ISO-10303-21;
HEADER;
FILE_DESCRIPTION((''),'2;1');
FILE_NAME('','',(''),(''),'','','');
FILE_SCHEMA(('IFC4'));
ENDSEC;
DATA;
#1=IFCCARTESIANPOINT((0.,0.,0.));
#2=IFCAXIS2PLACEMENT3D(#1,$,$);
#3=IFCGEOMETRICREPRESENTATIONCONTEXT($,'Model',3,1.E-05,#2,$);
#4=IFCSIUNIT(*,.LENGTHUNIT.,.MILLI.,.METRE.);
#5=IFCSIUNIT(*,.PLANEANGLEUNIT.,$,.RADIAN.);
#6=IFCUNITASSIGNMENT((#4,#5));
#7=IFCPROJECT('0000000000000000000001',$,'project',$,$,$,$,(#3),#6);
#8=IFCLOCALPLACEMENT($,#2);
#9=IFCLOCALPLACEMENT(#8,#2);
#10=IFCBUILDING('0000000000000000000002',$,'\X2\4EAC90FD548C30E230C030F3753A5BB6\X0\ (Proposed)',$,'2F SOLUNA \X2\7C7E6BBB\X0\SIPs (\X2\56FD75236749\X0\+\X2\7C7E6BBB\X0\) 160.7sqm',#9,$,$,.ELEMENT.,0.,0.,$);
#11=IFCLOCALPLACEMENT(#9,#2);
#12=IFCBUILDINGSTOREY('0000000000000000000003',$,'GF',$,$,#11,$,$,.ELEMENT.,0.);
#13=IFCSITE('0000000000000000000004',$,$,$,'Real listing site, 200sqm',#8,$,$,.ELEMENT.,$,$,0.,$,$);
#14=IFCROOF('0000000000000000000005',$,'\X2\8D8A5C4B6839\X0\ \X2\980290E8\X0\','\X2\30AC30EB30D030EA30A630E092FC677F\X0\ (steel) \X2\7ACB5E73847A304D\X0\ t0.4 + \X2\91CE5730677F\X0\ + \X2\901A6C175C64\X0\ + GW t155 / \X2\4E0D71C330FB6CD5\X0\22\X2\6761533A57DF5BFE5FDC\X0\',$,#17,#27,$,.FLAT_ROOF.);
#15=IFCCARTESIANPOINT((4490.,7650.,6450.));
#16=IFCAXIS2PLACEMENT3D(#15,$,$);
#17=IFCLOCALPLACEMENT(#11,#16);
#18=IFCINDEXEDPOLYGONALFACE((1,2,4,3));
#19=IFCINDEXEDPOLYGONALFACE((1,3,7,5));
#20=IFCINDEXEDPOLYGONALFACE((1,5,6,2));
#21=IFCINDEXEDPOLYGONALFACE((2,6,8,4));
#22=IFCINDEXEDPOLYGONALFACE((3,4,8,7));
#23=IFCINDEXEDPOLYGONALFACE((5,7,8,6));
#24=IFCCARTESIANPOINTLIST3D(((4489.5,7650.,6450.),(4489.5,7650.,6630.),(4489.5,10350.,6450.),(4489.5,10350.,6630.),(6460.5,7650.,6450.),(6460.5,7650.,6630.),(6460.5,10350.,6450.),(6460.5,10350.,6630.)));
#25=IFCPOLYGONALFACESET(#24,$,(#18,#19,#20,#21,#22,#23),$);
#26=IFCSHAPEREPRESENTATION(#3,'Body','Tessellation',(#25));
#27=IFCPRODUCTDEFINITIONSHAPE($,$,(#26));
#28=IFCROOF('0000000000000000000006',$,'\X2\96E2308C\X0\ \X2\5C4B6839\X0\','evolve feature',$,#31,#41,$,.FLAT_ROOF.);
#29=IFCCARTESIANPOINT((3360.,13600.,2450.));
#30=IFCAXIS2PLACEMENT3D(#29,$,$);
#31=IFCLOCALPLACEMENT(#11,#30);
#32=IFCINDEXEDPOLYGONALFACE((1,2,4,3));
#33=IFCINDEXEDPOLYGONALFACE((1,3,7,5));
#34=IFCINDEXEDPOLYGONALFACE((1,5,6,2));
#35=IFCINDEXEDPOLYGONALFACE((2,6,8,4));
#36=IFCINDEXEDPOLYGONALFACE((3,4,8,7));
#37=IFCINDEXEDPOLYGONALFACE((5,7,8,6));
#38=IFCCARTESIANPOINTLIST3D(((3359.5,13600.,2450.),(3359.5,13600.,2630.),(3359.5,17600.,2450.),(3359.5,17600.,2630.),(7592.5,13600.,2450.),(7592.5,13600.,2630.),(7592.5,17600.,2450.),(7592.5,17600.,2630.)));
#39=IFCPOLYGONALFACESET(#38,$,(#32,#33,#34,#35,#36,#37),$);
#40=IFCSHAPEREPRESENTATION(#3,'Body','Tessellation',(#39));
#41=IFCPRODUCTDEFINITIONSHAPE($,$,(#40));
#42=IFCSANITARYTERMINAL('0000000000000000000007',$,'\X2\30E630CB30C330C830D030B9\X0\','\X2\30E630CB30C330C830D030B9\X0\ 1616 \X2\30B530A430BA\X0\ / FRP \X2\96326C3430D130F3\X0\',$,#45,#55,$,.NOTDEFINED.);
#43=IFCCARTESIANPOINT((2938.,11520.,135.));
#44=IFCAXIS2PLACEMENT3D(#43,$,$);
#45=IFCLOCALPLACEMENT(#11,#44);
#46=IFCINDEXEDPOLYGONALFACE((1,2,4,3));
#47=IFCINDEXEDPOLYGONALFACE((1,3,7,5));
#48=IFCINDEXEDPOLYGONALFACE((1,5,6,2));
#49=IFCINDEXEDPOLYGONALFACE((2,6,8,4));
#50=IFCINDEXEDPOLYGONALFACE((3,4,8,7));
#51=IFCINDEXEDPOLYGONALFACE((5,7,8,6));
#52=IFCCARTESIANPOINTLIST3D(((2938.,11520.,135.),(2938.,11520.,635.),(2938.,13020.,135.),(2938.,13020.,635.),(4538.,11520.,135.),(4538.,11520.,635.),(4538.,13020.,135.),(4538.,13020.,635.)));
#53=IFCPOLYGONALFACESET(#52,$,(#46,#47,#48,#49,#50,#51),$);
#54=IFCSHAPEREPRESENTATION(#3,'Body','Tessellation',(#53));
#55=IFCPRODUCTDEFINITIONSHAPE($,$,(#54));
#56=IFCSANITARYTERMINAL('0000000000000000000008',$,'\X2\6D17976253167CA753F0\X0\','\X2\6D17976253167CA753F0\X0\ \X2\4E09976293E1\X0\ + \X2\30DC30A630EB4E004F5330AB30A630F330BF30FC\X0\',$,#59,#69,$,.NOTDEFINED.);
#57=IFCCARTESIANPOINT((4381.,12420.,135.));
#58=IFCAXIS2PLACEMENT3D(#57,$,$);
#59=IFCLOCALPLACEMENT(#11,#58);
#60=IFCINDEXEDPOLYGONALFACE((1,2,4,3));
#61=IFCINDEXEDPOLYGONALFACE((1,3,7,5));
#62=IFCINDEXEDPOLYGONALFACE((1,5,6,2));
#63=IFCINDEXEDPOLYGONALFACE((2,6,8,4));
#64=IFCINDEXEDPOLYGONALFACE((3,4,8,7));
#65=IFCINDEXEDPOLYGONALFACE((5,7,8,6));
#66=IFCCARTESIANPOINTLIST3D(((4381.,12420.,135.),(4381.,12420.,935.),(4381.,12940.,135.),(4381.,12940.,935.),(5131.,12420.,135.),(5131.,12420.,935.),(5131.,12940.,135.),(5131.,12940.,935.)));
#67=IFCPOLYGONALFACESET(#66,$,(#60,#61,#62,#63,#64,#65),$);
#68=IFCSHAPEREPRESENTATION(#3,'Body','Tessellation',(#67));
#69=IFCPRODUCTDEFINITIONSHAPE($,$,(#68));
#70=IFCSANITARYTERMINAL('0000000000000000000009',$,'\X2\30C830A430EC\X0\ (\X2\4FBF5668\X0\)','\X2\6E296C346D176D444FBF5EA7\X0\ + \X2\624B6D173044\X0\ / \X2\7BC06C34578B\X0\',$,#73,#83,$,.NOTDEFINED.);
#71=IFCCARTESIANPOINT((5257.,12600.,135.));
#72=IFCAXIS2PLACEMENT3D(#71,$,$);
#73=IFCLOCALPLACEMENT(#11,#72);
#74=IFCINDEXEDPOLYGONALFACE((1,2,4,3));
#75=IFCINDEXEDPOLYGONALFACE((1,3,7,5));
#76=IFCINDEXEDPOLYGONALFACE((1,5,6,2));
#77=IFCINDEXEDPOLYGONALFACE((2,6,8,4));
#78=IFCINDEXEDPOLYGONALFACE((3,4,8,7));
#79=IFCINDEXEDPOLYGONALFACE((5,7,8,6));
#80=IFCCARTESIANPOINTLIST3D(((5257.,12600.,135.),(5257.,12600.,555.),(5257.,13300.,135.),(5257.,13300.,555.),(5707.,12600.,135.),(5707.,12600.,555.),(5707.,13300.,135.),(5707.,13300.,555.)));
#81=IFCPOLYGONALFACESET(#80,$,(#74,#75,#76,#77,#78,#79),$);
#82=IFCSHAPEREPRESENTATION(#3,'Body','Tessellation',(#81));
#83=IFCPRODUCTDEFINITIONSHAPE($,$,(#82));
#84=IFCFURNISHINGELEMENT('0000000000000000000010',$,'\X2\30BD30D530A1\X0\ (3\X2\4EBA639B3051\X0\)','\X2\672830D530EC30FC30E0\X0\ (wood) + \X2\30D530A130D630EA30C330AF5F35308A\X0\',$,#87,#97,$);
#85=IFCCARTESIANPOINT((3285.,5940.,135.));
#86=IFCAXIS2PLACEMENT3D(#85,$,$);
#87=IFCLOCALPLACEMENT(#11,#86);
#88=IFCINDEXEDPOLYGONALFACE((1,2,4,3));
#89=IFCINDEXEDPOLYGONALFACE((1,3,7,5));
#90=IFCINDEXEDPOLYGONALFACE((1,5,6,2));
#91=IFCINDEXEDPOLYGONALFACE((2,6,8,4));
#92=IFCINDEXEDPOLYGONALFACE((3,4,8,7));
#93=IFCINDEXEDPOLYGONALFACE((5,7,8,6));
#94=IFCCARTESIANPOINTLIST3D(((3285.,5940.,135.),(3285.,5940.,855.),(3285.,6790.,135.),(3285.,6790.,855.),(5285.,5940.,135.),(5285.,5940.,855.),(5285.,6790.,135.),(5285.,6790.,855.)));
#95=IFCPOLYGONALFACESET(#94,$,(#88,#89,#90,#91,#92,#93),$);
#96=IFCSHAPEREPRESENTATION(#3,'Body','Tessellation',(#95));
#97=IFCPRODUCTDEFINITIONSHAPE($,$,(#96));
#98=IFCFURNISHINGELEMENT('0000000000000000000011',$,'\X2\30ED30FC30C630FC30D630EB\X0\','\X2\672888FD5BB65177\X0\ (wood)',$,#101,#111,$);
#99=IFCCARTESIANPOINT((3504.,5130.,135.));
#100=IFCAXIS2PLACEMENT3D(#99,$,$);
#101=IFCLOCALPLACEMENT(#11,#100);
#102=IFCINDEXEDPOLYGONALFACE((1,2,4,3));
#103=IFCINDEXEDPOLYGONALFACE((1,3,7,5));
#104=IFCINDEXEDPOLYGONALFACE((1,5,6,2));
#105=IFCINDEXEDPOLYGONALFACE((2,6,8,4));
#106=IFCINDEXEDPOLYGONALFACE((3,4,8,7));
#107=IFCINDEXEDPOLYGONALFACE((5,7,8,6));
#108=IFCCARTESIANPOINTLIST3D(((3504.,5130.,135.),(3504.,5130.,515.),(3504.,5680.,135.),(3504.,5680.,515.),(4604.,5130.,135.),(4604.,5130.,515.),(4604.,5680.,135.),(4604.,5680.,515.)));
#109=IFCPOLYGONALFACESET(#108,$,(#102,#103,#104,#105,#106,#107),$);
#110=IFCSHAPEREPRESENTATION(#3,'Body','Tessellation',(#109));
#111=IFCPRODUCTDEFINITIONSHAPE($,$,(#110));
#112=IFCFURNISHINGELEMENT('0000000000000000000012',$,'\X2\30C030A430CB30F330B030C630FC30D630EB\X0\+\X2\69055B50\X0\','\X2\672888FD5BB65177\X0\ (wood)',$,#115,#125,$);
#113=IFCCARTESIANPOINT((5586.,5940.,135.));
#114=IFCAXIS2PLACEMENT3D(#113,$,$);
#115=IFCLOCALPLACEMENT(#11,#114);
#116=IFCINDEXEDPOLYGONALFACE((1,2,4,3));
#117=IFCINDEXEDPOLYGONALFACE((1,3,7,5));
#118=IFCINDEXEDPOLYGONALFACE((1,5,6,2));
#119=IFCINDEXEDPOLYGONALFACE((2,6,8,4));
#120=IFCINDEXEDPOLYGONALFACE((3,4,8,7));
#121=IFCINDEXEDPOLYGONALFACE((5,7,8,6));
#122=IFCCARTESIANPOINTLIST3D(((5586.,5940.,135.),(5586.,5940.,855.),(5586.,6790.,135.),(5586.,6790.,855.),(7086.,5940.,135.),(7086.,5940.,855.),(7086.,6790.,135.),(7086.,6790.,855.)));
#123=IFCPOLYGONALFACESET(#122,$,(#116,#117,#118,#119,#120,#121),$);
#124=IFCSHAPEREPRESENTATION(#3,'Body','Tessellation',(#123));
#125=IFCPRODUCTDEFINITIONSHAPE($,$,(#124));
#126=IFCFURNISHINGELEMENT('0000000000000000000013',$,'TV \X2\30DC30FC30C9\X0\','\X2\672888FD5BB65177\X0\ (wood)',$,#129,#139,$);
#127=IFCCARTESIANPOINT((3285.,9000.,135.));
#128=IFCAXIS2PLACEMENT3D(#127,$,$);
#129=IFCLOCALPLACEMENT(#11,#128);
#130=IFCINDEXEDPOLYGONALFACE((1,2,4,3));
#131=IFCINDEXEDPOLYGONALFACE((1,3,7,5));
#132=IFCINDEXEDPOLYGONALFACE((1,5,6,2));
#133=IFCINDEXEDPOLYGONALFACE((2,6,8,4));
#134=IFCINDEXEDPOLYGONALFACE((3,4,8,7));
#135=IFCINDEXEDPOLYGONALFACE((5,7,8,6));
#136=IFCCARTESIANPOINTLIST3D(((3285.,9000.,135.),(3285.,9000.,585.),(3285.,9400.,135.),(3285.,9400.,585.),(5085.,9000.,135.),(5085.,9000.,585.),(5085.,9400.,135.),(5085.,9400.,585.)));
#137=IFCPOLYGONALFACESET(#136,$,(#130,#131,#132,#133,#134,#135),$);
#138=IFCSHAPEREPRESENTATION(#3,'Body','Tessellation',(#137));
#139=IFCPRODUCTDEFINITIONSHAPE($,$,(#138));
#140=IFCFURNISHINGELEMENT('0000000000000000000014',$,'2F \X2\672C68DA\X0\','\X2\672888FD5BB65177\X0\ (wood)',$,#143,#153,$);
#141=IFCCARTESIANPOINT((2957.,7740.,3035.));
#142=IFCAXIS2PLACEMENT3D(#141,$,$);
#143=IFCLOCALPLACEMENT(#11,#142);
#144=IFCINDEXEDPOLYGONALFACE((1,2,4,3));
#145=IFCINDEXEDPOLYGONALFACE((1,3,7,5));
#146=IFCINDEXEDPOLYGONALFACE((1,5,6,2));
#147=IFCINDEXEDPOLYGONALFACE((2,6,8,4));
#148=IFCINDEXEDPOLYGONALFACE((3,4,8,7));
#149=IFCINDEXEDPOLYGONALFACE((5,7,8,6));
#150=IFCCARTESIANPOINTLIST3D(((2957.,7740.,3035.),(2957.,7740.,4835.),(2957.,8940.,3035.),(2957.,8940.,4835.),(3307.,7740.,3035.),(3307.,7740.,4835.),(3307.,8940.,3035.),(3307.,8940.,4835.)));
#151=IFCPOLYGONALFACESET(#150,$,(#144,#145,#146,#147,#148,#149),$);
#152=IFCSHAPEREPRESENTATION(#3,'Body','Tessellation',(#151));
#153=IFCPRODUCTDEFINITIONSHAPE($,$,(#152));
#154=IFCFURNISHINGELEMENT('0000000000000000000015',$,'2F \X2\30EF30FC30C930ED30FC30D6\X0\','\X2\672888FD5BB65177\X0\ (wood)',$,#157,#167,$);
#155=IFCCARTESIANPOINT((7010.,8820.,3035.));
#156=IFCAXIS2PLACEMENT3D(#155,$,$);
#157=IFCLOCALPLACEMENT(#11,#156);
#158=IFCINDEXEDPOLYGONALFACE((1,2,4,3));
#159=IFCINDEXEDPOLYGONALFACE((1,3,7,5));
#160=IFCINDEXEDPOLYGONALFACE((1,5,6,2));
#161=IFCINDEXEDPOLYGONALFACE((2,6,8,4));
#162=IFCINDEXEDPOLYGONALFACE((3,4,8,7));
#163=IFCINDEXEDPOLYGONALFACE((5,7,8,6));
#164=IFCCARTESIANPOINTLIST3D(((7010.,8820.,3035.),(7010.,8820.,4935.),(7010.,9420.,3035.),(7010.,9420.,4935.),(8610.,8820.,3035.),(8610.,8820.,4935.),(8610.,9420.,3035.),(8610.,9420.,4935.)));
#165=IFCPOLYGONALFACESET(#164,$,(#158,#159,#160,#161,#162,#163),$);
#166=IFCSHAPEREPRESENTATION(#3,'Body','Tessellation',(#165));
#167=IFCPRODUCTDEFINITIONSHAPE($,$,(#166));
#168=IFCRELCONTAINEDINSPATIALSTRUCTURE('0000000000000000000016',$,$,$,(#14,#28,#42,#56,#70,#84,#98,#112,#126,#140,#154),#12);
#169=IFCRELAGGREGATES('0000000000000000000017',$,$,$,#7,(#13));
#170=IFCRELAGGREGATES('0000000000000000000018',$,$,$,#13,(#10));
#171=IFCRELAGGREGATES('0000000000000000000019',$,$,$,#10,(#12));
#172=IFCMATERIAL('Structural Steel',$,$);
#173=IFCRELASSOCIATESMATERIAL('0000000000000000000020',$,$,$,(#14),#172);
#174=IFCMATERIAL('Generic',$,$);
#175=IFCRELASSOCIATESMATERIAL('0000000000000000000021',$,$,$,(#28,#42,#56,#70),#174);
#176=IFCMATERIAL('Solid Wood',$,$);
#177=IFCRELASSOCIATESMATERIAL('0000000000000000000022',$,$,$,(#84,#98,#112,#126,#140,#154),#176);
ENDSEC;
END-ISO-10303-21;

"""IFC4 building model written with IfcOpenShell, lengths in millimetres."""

from ifc_helpers import new_model, si_unit, frame, frame_2d, origin, place, context, project, spatial, rectangle, extrude, material, element, save


model = new_model("IFC4")

# Units and contexts
model_context = context("Model", 3, precision=1e-05, world=origin())
ifc_project = project(units=[si_unit("LENGTHUNIT", "METRE", prefix="MILLI"), si_unit("PLANEANGLEUNIT", "RADIAN")], contexts=[model_context])

# Site, building, storey
site_placement = place(None, origin())
site = spatial("IfcSite", under=ifc_project, at=site_placement, ObjectType="Real listing site, 200sqm", CompositionType="ELEMENT", RefElevation=0.0)
building_placement = place(site_placement, origin())
building = spatial("IfcBuilding", under=site, at=building_placement, Name="京都和モダン町家 (Proposed)", ObjectType="2F SOLUNA 籾殻SIPs (国産杉+籾殻) 160.7sqm", CompositionType="ELEMENT", ElevationOfRefHeight=0.0, ElevationOfTerrain=0.0)
storey_placement = place(building_placement, origin())
storey = spatial("IfcBuildingStorey", under=building, at=storey_placement, Name="GF", CompositionType="ELEMENT", Elevation=0.0)

# Shared definitions
ifc_material_1 = material(Name="Generic")

# Shared definitions
ifc_material_2 = material(Name="Solid Wood")

# Roofs
ifc_material_3 = material(Name="Structural Steel")
roof_1_placement = place(storey_placement, frame((4490.0, 7650.0, 6450.0)))
element("IfcRoof", 1, at=roof_1_placement, inside=storey, material=ifc_material_3, Name="越屋根 頂部", Description="ガルバリウム鋼板 (steel) 立平葺き t0.4 + 野地板 + 通気層 + GW t155 / 不燃・法22条区域対応", PredefinedType="FLAT_ROOF", context=model_context, shape_type="SweptSolid", body=[
    extrude(rectangle(XDim=1971.0, YDim=2700.0, at=frame_2d((985.0, 1350.0))), frame((4490.0, 7650.0, 6450.0)), (0.0, 0.0, 1.0), 180.0),
])
roof_2_placement = place(storey_placement, frame((3360.0, 13600.0, 2450.0)))
element("IfcRoof", 2, at=roof_2_placement, inside=storey, material=ifc_material_1, Name="離れ 屋根", Description="evolve feature", PredefinedType="FLAT_ROOF", context=model_context, shape_type="SweptSolid", body=[
    extrude(rectangle(XDim=4233.0, YDim=4000.0, at=frame_2d((2116.0, 2000.0))), frame((3360.0, 13600.0, 2450.0)), (0.0, 0.0, 1.0), 180.0),
])

# Sanitary terminals
sanitary_terminal_1_placement = place(storey_placement, frame((2938.0, 11520.0, 135.0)))
element("IfcSanitaryTerminal", 3, at=sanitary_terminal_1_placement, inside=storey, material=ifc_material_1, Name="ユニットバス", Description="ユニットバス 1616 サイズ / FRP 防水パン", PredefinedType="NOTDEFINED", context=model_context, shape_type="SweptSolid", body=[
    extrude(rectangle(XDim=1600.0, YDim=1500.0, at=frame_2d((800.0, 750.0))), frame((2938.0, 11520.0, 135.0)), (0.0, 0.0, 1.0), 500.0),
])
sanitary_terminal_2_placement = place(storey_placement, frame((4381.0, 12420.0, 135.0)))
element("IfcSanitaryTerminal", 4, at=sanitary_terminal_2_placement, inside=storey, material=ifc_material_1, Name="洗面化粧台", Description="洗面化粧台 三面鏡 + ボウル一体カウンター", PredefinedType="NOTDEFINED", context=model_context, shape_type="SweptSolid", body=[
    extrude(rectangle(XDim=750.0, YDim=520.0, at=frame_2d((375.0, 260.0))), frame((4381.0, 12420.0, 135.0)), (0.0, 0.0, 1.0), 800.0),
])
sanitary_terminal_3_placement = place(storey_placement, frame((5257.0, 12600.0, 135.0)))
element("IfcSanitaryTerminal", 5, at=sanitary_terminal_3_placement, inside=storey, material=ifc_material_1, Name="トイレ (便器)", Description="温水洗浄便座 + 手洗い / 節水型", PredefinedType="NOTDEFINED", context=model_context, shape_type="SweptSolid", body=[
    extrude(rectangle(XDim=450.0, YDim=700.0, at=frame_2d((225.0, 350.0))), frame((5257.0, 12600.0, 135.0)), (0.0, 0.0, 1.0), 420.0),
])

# Furnishing elements
furnishing_1_placement = place(storey_placement, frame((3285.0, 5940.0, 135.0)))
element("IfcFurnishingElement", 6, at=furnishing_1_placement, inside=storey, material=ifc_material_2, Name="ソファ (3人掛け)", Description="木フレーム (wood) + ファブリック張り", context=model_context, shape_type="SweptSolid", body=[
    extrude(rectangle(XDim=2000.0, YDim=850.0, at=frame_2d((1000.0, 425.0))), frame((3285.0, 5940.0, 135.0)), (0.0, 0.0, 1.0), 720.0),
])
furnishing_2_placement = place(storey_placement, frame((3504.0, 5130.0, 135.0)))
element("IfcFurnishingElement", 7, at=furnishing_2_placement, inside=storey, material=ifc_material_2, Name="ローテーブル", Description="木製家具 (wood)", context=model_context, shape_type="SweptSolid", body=[
    extrude(rectangle(XDim=1100.0, YDim=550.0, at=frame_2d((550.0, 275.0))), frame((3504.0, 5130.0, 135.0)), (0.0, 0.0, 1.0), 380.0),
])
furnishing_3_placement = place(storey_placement, frame((5586.0, 5940.0, 135.0)))
element("IfcFurnishingElement", 8, at=furnishing_3_placement, inside=storey, material=ifc_material_2, Name="ダイニングテーブル+椅子", Description="木製家具 (wood)", context=model_context, shape_type="SweptSolid", body=[
    extrude(rectangle(XDim=1500.0, YDim=850.0, at=frame_2d((750.0, 425.0))), frame((5586.0, 5940.0, 135.0)), (0.0, 0.0, 1.0), 720.0),
])
furnishing_4_placement = place(storey_placement, frame((3285.0, 9000.0, 135.0)))
element("IfcFurnishingElement", 9, at=furnishing_4_placement, inside=storey, material=ifc_material_2, Name="TV ボード", Description="木製家具 (wood)", context=model_context, shape_type="SweptSolid", body=[
    extrude(rectangle(XDim=1800.0, YDim=400.0, at=frame_2d((900.0, 200.0))), frame((3285.0, 9000.0, 135.0)), (0.0, 0.0, 1.0), 450.0),
])
furnishing_5_placement = place(storey_placement, frame((2957.0, 7740.0, 3035.0)))
element("IfcFurnishingElement", 10, at=furnishing_5_placement, inside=storey, material=ifc_material_2, Name="2F 本棚", Description="木製家具 (wood)", context=model_context, shape_type="SweptSolid", body=[
    extrude(rectangle(XDim=350.0, YDim=1200.0, at=frame_2d((175.0, 600.0))), frame((2957.0, 7740.0, 3035.0)), (0.0, 0.0, 1.0), 1800.0),
])
furnishing_6_placement = place(storey_placement, frame((7010.0, 8820.0, 3035.0)))
element("IfcFurnishingElement", 11, at=furnishing_6_placement, inside=storey, material=ifc_material_2, Name="2F ワードローブ", Description="木製家具 (wood)", context=model_context, shape_type="SweptSolid", body=[
    extrude(rectangle(XDim=1600.0, YDim=600.0, at=frame_2d((800.0, 300.0))), frame((7010.0, 8820.0, 3035.0)), (0.0, 0.0, 1.0), 1900.0),
])

save(model, "model.ifc")
